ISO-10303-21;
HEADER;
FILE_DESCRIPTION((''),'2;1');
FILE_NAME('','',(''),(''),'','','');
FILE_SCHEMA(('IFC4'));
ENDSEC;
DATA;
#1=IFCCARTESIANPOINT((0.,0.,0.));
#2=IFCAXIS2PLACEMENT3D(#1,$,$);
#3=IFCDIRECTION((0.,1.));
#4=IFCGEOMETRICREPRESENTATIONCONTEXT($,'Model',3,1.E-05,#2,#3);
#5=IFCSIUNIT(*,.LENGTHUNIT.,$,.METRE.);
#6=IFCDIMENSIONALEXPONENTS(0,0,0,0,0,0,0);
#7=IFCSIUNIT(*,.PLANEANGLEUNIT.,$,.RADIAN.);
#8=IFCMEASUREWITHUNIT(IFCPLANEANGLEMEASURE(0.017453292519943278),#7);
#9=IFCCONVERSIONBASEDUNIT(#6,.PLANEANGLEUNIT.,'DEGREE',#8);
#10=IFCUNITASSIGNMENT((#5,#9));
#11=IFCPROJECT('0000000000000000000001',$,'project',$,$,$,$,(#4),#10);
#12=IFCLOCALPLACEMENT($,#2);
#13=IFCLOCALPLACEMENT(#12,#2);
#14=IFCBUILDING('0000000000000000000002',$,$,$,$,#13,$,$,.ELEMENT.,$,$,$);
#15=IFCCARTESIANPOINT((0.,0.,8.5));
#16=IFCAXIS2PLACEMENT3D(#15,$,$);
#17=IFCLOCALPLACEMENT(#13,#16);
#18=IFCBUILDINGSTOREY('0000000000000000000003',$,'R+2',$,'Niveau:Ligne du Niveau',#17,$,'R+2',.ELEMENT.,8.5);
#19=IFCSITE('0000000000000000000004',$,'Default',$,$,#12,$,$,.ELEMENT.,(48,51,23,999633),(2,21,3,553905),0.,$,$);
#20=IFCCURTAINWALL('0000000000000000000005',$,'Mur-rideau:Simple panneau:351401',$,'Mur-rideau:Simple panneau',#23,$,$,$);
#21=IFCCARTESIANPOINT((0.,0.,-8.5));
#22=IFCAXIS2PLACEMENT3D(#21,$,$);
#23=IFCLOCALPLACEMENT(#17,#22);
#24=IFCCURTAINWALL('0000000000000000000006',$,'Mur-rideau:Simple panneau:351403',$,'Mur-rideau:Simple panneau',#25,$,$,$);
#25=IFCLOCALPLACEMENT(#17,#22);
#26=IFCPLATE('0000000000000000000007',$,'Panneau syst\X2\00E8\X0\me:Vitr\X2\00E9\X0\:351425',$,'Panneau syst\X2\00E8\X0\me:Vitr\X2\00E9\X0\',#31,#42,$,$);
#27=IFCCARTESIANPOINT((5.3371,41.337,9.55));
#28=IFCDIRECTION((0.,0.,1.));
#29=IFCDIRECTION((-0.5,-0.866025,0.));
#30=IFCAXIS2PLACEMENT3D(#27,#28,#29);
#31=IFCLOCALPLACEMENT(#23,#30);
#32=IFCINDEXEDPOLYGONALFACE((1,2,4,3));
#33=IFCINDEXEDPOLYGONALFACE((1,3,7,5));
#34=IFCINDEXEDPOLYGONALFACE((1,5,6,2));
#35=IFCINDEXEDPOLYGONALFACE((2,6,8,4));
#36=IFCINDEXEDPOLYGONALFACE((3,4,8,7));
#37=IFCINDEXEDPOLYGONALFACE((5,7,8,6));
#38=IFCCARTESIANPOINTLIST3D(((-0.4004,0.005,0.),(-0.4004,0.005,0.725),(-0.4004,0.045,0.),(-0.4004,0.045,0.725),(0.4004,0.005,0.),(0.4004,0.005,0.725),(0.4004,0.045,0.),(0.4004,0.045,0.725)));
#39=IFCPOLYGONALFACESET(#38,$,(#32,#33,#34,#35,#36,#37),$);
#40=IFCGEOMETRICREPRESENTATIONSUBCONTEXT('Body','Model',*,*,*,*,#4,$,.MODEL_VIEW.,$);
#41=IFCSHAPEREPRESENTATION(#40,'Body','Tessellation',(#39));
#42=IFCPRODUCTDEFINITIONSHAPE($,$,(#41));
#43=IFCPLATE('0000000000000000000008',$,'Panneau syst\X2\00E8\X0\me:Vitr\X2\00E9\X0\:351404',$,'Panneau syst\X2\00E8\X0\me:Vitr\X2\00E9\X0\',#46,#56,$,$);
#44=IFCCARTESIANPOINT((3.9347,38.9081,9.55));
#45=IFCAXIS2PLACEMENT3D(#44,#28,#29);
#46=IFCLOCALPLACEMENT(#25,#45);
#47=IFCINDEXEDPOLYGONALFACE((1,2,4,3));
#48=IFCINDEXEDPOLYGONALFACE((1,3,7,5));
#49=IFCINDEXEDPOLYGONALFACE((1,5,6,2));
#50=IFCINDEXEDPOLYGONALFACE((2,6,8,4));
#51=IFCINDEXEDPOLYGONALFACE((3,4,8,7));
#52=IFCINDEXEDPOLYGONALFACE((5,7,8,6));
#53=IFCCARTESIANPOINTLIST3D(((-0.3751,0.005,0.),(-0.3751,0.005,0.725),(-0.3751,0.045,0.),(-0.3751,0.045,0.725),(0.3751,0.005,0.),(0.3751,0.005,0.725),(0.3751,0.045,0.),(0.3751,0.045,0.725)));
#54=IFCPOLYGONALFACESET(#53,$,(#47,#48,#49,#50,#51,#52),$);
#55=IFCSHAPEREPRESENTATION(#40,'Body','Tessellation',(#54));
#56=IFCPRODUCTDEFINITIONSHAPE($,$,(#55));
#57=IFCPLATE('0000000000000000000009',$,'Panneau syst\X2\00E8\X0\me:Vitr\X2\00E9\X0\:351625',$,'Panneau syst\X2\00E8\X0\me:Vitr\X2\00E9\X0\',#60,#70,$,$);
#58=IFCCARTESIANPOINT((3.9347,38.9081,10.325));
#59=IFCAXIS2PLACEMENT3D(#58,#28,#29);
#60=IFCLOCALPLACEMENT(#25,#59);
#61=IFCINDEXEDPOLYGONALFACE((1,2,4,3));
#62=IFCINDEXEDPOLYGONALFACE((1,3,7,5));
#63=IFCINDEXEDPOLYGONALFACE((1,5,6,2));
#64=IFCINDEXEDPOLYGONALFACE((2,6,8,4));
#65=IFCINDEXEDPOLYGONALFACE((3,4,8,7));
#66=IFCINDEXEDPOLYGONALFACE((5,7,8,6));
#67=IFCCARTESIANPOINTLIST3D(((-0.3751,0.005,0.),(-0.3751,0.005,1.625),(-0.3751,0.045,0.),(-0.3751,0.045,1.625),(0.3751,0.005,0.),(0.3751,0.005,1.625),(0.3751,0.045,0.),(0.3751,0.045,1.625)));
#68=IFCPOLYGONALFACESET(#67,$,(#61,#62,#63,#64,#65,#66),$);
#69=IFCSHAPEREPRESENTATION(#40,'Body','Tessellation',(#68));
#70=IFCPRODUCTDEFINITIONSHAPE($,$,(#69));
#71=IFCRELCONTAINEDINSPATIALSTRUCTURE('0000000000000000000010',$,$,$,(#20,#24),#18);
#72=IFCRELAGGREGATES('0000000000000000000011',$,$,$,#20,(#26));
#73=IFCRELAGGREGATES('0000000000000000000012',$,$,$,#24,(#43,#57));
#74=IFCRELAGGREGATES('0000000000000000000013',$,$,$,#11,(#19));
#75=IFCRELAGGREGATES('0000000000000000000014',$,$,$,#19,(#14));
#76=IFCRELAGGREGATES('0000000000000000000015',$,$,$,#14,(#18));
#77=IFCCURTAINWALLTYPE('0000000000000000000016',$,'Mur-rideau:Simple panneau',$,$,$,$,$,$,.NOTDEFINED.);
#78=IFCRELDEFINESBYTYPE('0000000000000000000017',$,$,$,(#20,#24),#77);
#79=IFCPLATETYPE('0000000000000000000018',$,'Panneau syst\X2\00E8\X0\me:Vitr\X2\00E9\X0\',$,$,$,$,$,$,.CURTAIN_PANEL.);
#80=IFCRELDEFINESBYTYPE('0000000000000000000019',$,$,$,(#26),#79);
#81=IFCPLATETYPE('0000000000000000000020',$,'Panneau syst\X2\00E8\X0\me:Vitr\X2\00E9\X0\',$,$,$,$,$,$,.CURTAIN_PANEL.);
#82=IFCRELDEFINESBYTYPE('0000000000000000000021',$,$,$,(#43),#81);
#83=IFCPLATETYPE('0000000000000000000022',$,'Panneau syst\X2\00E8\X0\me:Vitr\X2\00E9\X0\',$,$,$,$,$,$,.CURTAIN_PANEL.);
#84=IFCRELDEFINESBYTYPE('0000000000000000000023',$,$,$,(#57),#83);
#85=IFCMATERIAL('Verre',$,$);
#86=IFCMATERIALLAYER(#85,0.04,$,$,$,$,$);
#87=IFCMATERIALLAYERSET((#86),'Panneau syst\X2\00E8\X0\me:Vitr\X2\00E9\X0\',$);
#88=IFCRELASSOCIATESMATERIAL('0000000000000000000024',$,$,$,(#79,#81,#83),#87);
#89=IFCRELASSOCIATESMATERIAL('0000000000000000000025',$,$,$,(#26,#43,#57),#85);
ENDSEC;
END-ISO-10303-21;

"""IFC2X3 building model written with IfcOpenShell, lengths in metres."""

from ifc_helpers import new_model, entity, si_unit, converted_unit, direction, frame, frame_2d, origin, place, context, subcontext, project, spatial, rectangle, extrude, source, transform, mapped, material, layer, layer_set, type_object, type_shapes, element, aggregate, save


model = new_model("IFC2X3")

# Units and contexts
model_context = context("Model", 3, precision=1e-05, world=origin(), true_north=direction((0.0, 1.0)))
body_context = subcontext(model_context, "Body", "Model", "MODEL_VIEW")
ifc_project = project(units=[si_unit("LENGTHUNIT", "METRE"), converted_unit("PLANEANGLEUNIT", "DEGREE", entity("IfcPlaneAngleMeasure", 0.017453292519943278), si_unit("PLANEANGLEUNIT", "RADIAN"), dimensions=[0, 0, 0, 0, 0, 0, 0])], contexts=[model_context])

# Site, building, storey
site_placement = place(None, origin())
site = spatial("IfcSite", under=ifc_project, at=site_placement, Name="Default", CompositionType="ELEMENT", RefLatitude=(48, 51, 23, 999633), RefLongitude=(2, 21, 3, 553905), RefElevation=0.0)
building_placement = place(site_placement, origin())
building = spatial("IfcBuilding", under=site, at=building_placement, CompositionType="ELEMENT")
storey_placement = place(building_placement, frame((0.0, 0.0, 8.5)))
storey = spatial("IfcBuildingStorey", under=building, at=storey_placement, Name="R+2", ObjectType="Niveau:Ligne du Niveau", LongName="R+2", CompositionType="ELEMENT", Elevation=8.5)

# Curtain wall
curtain_wall_type = type_object("IfcCurtainWallType", Name="Mur-rideau:Simple panneau", PredefinedType="NOTDEFINED")
curtain_wall_1_placement = place(storey_placement, frame((0.0, 0.0, -8.5)))
curtain_wall_1 = element("IfcCurtainWall", 1, at=curtain_wall_1_placement, inside=storey, type_object=curtain_wall_type, Name="Mur-rideau:Simple panneau:351401", ObjectType="Mur-rideau:Simple panneau")

# Curtain wall
curtain_wall_2_placement = place(storey_placement, frame((0.0, 0.0, -8.5)))
curtain_wall_2 = element("IfcCurtainWall", 2, at=curtain_wall_2_placement, inside=storey, type_object=curtain_wall_type, Name="Mur-rideau:Simple panneau:351403", ObjectType="Mur-rideau:Simple panneau")

# Plates
ifc_material_1 = material(Name="Verre")
ifc_layer_1 = layer(ifc_material_1, 0.04)
ifc_layer_set_1 = layer_set([ifc_layer_1], Name="Panneau système:Vitré")
plate_type_1 = type_object("IfcPlateType", Name="Panneau système:Vitré", PredefinedType="CURTAIN_PANEL", material=ifc_layer_set_1)
shared_shape_1 = source(origin(), body_context, "Body", "SweptSolid", [
    extrude(rectangle(XDim=0.04, YDim=0.8008, at=frame_2d((0.0, 0.0), x_axis=(1.0, 0.0))), frame((0.0, 0.025, 0.0), z_axis=(0.0, 0.0, 1.0), x_axis=(0.0, 1.0, 0.0)), (0.0, 0.0, 1.0), 0.725),
])
type_shapes(plate_type_1, [shared_shape_1])
plate_1_placement = place(curtain_wall_1_placement, frame((5.3371, 41.337, 9.55), z_axis=(0.0, 0.0, 1.0), x_axis=(-0.5, -0.866025, 0.0)))
plate_1 = element("IfcPlate", 3, at=plate_1_placement, type_object=plate_type_1, material=ifc_material_1, Name="Panneau système:Vitré:351425", ObjectType="Panneau système:Vitré", context=body_context, shape_type="MappedRepresentation", body=[
    mapped(shared_shape_1, transform((0.0, 0.0, 0.0), scale=1.0)),
])
aggregate(curtain_wall_1, [plate_1])
plate_type_2 = type_object("IfcPlateType", Name="Panneau système:Vitré", PredefinedType="CURTAIN_PANEL", material=ifc_layer_set_1)
shared_shape_2 = source(origin(), body_context, "Body", "SweptSolid", [
    extrude(rectangle(XDim=0.04, YDim=0.7503, at=frame_2d((0.0, 0.0), x_axis=(1.0, 0.0))), frame((0.0, 0.025, 0.0), z_axis=(0.0, 0.0, 1.0), x_axis=(0.0, 1.0, 0.0)), (0.0, 0.0, 1.0), 0.725),
])
type_shapes(plate_type_2, [shared_shape_2])
plate_2_placement = place(curtain_wall_2_placement, frame((3.9347, 38.9081, 9.55), z_axis=(0.0, 0.0, 1.0), x_axis=(-0.5, -0.866025, 0.0)))
plate_2 = element("IfcPlate", 4, at=plate_2_placement, type_object=plate_type_2, material=ifc_material_1, Name="Panneau système:Vitré:351404", ObjectType="Panneau système:Vitré", context=body_context, shape_type="MappedRepresentation", body=[
    mapped(shared_shape_2, transform((0.0, 0.0, 0.0), scale=1.0)),
])
plate_type_3 = type_object("IfcPlateType", Name="Panneau système:Vitré", PredefinedType="CURTAIN_PANEL", material=ifc_layer_set_1)
shared_shape_3 = source(origin(), body_context, "Body", "SweptSolid", [
    extrude(rectangle(XDim=0.04, YDim=0.7503, at=frame_2d((0.0, 0.0), x_axis=(1.0, 0.0))), frame((0.0, 0.025, 0.0), z_axis=(0.0, 0.0, 1.0), x_axis=(0.0, 1.0, 0.0)), (0.0, 0.0, 1.0), 1.625),
])
type_shapes(plate_type_3, [shared_shape_3])
plate_3_placement = place(curtain_wall_2_placement, frame((3.9347, 38.9081, 10.325), z_axis=(0.0, 0.0, 1.0), x_axis=(-0.5, -0.866025, 0.0)))
plate_3 = element("IfcPlate", 5, at=plate_3_placement, type_object=plate_type_3, material=ifc_material_1, Name="Panneau système:Vitré:351625", ObjectType="Panneau système:Vitré", context=body_context, shape_type="MappedRepresentation", body=[
    mapped(shared_shape_3, transform((0.0, 0.0, 0.0), scale=1.0)),
])
aggregate(curtain_wall_2, [plate_2, plate_3])

save(model, "model.ifc")
